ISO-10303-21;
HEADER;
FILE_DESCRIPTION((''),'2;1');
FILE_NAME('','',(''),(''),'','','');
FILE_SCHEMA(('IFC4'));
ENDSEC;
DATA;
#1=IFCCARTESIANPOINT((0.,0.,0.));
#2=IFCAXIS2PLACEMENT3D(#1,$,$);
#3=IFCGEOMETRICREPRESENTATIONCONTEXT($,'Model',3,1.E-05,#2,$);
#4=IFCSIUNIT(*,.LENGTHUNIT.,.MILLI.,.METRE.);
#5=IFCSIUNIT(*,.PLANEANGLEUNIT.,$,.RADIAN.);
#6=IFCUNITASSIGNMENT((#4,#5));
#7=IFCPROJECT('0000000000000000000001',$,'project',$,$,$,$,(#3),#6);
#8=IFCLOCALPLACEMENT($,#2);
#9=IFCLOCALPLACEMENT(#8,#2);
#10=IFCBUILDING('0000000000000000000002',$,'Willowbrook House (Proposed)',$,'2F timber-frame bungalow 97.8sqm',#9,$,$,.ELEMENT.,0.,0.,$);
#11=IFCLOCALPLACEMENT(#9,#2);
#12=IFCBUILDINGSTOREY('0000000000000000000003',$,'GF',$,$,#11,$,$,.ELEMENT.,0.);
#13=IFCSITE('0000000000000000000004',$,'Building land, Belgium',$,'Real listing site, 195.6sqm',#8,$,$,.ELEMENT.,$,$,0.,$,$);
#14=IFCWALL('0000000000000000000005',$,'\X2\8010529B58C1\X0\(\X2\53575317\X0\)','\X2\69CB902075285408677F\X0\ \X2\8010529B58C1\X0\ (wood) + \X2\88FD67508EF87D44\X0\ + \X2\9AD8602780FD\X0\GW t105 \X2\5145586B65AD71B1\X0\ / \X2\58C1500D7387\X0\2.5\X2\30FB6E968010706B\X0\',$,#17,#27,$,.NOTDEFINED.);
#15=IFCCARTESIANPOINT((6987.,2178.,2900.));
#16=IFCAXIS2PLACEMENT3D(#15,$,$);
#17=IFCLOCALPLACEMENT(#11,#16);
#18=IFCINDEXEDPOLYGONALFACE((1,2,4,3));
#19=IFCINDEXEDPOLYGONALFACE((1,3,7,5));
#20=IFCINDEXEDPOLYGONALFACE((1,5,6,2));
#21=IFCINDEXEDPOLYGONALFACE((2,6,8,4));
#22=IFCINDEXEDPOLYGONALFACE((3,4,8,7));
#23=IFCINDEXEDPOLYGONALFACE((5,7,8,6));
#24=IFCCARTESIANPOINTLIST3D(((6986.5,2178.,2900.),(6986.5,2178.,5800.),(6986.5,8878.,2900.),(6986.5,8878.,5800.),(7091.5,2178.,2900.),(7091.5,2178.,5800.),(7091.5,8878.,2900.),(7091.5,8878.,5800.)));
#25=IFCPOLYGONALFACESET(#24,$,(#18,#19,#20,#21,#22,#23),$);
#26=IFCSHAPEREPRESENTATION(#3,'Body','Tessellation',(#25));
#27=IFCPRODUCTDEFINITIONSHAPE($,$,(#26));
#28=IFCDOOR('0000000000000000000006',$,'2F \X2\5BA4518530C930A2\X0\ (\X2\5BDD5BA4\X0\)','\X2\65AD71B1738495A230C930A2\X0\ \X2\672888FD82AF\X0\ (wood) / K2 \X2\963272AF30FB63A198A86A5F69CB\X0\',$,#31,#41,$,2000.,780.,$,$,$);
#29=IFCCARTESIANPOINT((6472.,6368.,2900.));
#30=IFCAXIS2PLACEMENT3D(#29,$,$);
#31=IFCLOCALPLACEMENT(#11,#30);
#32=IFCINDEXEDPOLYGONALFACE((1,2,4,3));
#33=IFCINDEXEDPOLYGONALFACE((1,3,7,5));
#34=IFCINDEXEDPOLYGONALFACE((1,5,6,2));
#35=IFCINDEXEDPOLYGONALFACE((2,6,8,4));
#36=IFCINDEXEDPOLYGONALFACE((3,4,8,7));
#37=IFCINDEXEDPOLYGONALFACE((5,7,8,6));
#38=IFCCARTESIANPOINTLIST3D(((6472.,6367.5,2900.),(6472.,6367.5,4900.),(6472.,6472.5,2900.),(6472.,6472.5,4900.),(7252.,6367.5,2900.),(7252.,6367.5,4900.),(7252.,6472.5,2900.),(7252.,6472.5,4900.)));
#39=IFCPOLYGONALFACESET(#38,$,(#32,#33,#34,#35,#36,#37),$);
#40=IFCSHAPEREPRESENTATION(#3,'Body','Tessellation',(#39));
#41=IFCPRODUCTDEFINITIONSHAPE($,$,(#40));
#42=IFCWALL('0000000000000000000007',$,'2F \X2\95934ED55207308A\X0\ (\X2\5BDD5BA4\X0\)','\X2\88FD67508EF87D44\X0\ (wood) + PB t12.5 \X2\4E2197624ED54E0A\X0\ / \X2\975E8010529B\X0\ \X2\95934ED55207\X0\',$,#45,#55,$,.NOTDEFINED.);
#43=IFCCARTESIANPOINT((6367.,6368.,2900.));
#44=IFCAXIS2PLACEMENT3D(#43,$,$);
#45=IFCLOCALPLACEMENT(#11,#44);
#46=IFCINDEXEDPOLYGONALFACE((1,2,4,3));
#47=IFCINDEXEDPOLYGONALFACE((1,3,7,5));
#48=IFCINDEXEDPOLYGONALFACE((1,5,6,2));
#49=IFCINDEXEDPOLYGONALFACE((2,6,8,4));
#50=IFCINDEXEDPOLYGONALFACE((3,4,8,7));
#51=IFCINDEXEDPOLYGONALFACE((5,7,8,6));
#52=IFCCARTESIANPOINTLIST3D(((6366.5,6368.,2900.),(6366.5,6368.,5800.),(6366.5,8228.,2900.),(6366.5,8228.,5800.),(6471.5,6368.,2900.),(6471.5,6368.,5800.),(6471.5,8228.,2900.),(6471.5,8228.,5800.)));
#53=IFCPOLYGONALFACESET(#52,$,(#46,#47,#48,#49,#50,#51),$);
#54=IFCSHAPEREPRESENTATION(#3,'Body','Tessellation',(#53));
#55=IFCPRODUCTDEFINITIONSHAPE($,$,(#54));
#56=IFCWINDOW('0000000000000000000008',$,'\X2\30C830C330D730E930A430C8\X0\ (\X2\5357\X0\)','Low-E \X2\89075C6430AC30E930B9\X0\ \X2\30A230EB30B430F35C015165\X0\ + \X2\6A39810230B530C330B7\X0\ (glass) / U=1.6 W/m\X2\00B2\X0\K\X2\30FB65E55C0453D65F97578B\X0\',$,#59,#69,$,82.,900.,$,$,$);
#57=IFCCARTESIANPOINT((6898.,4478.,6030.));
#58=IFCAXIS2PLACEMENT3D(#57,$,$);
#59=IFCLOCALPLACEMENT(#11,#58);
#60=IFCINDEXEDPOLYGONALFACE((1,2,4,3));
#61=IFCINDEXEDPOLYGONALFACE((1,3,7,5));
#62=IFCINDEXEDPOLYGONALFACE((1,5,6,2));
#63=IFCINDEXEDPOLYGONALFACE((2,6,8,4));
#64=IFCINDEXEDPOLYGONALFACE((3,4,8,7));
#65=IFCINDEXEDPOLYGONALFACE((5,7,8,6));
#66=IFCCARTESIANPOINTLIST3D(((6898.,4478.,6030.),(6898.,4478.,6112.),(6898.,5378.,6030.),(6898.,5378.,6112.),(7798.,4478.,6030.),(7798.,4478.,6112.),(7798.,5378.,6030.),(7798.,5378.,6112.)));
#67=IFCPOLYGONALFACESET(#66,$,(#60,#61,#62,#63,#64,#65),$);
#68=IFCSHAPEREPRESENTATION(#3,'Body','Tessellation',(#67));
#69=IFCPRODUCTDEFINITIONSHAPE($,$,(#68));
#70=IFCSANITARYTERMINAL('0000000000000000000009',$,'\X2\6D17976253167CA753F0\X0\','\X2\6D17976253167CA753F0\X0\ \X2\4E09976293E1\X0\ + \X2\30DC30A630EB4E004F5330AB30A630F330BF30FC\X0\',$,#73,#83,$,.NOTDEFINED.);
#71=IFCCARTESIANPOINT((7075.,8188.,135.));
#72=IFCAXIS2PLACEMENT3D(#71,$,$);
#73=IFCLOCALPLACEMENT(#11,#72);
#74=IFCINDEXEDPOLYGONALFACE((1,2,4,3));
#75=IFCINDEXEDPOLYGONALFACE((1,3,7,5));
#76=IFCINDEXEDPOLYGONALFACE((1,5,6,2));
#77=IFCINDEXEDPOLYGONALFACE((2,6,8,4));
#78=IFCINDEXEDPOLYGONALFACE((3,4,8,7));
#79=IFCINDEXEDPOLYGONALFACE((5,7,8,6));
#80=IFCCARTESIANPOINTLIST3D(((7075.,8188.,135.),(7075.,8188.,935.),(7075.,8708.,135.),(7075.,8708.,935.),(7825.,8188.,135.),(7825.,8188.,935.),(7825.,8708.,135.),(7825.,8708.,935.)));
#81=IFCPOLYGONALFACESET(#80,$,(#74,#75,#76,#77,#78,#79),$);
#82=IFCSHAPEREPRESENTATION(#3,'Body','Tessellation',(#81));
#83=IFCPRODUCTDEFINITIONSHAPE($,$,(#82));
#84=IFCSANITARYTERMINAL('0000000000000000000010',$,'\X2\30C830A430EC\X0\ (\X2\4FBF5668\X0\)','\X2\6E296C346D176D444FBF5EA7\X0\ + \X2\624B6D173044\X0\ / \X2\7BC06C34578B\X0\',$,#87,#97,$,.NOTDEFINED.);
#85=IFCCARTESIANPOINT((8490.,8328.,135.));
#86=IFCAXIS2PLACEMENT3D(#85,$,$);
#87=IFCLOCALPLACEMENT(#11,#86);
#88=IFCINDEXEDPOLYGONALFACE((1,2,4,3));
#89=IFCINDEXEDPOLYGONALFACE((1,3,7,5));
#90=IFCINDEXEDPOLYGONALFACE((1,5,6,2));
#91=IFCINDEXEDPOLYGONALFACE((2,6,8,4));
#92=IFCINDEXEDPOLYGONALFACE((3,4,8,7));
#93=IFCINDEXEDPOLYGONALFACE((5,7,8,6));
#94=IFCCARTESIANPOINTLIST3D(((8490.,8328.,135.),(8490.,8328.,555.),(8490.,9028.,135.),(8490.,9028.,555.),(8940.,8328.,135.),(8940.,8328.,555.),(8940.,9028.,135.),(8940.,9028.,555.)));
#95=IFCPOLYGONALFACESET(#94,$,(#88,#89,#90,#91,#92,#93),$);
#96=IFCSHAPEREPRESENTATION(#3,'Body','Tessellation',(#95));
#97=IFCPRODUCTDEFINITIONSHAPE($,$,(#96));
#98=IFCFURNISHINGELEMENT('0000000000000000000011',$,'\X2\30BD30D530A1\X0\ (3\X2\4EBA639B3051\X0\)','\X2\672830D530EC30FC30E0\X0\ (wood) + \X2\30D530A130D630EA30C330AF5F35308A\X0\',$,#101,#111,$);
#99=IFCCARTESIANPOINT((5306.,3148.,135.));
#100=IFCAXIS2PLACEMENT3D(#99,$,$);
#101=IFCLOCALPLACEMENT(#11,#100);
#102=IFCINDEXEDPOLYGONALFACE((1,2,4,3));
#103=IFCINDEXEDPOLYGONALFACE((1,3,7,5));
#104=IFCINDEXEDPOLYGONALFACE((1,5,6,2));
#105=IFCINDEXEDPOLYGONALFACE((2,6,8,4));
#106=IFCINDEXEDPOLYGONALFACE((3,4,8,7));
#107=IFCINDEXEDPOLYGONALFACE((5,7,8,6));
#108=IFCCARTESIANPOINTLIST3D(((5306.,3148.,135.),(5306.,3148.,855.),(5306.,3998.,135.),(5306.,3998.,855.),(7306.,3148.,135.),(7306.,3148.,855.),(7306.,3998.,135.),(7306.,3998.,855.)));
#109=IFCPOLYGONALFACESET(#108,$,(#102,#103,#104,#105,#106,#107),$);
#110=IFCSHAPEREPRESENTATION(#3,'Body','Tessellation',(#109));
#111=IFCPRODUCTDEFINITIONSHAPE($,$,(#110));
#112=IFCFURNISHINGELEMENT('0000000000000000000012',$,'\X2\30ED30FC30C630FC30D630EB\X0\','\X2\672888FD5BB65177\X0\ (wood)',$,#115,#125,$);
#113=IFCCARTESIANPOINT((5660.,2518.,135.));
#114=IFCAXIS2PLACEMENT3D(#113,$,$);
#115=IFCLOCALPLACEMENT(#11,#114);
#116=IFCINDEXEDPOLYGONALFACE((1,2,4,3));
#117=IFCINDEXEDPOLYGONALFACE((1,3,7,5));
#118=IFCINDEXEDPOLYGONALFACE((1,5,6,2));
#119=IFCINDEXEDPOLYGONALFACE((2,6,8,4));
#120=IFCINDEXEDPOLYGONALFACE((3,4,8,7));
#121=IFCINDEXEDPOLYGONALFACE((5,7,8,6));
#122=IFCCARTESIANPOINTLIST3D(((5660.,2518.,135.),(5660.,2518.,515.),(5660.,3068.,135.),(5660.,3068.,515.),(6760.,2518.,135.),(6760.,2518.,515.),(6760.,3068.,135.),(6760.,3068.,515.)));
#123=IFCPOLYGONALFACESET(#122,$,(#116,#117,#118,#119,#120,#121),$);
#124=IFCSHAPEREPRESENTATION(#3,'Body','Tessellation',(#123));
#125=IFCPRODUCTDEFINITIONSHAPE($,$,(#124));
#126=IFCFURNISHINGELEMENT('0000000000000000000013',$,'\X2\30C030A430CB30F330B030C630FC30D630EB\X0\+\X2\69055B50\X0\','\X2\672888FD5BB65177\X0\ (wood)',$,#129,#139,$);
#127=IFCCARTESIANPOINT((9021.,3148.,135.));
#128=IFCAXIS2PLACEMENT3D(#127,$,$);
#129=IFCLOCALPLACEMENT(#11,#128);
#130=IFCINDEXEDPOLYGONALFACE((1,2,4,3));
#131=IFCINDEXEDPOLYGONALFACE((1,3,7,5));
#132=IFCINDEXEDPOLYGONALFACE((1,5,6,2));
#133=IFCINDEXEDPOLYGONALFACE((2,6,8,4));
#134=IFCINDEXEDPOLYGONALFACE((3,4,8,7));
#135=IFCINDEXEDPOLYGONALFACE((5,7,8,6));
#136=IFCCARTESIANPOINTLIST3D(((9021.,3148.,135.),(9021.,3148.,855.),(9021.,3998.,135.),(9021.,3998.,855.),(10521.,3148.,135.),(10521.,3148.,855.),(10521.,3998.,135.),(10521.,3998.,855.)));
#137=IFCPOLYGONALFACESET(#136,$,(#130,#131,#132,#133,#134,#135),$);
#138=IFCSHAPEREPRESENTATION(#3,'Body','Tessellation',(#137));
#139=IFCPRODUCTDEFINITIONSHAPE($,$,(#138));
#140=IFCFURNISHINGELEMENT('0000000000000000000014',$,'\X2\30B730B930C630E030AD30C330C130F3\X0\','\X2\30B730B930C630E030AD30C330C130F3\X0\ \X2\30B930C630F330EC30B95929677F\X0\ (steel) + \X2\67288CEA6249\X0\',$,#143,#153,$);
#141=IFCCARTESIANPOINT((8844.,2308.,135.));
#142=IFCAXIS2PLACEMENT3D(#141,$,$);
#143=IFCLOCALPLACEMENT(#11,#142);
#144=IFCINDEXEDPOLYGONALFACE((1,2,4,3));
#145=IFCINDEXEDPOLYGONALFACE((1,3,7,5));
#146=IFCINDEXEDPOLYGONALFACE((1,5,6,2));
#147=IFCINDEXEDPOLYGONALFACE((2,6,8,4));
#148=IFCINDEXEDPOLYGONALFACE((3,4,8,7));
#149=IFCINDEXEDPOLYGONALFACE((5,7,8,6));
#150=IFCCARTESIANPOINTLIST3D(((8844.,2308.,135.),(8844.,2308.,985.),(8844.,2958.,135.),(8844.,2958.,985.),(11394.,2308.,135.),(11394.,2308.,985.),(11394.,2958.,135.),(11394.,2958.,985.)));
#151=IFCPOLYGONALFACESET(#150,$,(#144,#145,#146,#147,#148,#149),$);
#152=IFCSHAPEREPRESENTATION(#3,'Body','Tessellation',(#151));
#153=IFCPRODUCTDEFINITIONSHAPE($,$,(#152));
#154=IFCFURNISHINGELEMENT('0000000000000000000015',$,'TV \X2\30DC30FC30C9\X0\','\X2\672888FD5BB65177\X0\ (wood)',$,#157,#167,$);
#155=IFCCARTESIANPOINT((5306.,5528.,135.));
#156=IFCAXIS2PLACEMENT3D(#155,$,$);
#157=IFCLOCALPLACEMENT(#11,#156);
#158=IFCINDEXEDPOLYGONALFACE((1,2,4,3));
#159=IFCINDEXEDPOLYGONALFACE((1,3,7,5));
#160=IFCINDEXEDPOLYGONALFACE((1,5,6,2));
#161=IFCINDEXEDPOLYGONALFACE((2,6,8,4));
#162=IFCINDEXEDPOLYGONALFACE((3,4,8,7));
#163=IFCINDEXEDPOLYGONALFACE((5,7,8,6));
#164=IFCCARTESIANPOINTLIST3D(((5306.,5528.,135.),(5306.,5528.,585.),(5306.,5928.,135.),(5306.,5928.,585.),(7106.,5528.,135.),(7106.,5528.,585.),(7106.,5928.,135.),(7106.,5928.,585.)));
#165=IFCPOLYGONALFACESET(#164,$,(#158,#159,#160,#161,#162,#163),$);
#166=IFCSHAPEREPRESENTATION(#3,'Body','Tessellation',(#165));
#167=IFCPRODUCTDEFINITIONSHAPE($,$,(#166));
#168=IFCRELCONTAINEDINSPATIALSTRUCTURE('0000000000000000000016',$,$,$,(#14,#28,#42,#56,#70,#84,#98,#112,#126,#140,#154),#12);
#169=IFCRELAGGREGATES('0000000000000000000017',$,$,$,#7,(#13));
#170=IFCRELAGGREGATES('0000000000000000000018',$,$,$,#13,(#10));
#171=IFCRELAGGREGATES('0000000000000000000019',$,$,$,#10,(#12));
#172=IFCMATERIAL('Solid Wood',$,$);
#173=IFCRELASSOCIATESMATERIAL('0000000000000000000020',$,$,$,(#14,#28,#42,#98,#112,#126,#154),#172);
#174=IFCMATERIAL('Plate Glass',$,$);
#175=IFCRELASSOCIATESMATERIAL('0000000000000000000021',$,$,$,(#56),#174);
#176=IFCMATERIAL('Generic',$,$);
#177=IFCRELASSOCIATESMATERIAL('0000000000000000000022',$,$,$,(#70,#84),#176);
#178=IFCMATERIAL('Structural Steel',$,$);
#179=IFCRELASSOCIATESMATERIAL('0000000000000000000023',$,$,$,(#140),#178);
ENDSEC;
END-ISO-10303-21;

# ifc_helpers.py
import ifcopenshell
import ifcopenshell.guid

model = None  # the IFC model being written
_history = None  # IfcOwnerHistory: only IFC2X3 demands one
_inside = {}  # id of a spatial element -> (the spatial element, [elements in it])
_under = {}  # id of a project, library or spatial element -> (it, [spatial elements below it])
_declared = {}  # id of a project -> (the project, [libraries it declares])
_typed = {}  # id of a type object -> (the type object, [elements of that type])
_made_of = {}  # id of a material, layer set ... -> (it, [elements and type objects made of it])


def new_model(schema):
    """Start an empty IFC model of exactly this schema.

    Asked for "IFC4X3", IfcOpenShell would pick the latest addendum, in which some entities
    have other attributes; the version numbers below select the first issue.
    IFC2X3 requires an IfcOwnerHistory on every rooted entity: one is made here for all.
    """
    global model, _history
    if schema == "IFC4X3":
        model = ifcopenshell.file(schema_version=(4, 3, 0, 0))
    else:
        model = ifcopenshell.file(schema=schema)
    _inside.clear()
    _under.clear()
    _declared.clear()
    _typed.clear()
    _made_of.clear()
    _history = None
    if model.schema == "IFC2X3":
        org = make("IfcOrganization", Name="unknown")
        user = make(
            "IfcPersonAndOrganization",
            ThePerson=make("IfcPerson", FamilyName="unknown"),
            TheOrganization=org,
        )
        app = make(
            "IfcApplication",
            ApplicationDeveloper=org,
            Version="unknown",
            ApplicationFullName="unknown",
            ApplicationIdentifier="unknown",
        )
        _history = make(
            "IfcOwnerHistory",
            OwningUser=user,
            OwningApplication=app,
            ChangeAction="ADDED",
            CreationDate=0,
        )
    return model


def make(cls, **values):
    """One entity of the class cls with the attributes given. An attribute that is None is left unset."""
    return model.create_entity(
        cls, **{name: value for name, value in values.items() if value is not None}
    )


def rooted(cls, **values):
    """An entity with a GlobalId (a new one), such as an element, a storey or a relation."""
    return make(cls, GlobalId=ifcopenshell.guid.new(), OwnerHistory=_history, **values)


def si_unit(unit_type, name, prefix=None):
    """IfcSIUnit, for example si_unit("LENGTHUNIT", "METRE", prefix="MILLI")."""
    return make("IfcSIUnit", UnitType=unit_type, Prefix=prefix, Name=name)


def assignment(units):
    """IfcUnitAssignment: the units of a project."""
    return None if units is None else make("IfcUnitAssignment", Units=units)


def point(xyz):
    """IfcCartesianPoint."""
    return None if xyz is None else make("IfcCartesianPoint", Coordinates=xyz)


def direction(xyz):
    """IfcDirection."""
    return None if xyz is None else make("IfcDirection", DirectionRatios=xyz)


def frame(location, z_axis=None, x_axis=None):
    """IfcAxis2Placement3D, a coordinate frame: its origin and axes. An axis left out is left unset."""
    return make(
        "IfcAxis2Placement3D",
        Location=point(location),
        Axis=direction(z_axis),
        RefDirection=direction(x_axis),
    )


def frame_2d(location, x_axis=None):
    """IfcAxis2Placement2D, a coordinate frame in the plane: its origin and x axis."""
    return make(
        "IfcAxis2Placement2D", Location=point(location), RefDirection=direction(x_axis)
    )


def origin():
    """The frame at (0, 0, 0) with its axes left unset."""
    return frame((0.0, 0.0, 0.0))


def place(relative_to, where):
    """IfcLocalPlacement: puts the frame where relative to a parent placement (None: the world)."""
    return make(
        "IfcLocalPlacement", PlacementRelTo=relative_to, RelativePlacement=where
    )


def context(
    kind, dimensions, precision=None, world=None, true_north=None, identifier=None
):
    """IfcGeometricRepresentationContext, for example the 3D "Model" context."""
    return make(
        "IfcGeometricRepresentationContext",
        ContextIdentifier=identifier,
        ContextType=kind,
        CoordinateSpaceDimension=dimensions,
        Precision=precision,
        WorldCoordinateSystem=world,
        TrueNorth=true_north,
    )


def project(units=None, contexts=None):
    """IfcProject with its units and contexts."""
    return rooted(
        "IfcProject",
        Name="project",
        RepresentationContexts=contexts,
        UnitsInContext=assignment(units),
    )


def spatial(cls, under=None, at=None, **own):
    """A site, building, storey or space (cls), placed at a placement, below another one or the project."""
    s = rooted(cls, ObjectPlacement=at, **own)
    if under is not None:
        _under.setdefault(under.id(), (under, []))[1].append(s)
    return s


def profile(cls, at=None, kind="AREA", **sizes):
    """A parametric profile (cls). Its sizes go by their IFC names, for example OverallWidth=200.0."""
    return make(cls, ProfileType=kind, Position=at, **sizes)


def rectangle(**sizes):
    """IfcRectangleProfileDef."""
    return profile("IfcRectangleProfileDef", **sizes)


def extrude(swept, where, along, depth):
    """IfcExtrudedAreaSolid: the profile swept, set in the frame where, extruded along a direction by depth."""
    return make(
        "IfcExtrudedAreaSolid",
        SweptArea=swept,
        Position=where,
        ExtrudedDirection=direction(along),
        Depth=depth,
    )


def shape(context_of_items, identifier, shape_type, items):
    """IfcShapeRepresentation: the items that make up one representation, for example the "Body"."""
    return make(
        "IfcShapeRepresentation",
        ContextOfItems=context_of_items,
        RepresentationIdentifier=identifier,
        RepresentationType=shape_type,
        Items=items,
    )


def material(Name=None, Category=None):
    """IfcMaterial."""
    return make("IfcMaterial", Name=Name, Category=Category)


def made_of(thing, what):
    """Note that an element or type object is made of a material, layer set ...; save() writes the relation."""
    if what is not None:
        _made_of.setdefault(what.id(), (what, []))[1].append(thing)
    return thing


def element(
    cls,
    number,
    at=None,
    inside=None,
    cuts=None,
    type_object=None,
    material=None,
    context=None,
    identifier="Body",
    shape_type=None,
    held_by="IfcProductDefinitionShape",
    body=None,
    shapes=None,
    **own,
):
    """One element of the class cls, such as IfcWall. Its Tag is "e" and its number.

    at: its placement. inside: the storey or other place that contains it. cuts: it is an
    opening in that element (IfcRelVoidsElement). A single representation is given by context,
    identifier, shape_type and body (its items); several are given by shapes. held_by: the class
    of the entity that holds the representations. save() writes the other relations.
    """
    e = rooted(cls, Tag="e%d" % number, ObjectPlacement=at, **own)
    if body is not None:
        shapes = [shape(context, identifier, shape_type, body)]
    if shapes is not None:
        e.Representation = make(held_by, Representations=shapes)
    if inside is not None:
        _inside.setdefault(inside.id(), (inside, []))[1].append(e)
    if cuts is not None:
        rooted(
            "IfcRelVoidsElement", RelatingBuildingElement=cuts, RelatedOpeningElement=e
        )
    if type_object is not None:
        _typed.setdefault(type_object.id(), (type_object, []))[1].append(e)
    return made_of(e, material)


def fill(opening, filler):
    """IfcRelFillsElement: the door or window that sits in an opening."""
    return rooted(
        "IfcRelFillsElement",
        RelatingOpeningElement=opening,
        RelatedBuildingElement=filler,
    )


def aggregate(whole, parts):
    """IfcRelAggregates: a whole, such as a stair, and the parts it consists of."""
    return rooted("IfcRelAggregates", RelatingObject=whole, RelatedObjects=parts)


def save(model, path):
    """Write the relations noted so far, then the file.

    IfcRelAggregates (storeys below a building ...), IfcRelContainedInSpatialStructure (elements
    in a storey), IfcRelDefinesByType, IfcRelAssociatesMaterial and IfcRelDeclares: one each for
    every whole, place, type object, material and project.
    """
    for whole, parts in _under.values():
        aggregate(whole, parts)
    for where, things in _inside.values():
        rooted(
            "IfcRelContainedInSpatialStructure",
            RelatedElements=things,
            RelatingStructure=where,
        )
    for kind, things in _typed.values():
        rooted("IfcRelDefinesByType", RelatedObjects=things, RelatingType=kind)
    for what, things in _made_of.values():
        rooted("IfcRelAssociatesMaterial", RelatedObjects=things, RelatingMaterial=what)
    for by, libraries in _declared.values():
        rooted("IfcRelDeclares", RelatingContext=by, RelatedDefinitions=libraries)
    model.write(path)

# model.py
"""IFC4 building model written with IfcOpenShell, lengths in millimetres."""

from ifc_helpers import new_model, si_unit, frame, frame_2d, origin, place, context, project, spatial, rectangle, extrude, material, element, fill, save


model = new_model("IFC4")

# Units and contexts
model_context = context("Model", 3, precision=1e-05, world=origin())
ifc_project = project(units=[si_unit("LENGTHUNIT", "METRE", prefix="MILLI"), si_unit("PLANEANGLEUNIT", "RADIAN")], contexts=[model_context])

# Site, building, storey
site_placement = place(None, origin())
site = spatial("IfcSite", under=ifc_project, at=site_placement, Name="Building land, Belgium", ObjectType="Real listing site, 195.6sqm", CompositionType="ELEMENT", RefElevation=0.0)
building_placement = place(site_placement, origin())
building = spatial("IfcBuilding", under=site, at=building_placement, Name="Willowbrook House (Proposed)", ObjectType="2F timber-frame bungalow 97.8sqm", CompositionType="ELEMENT", ElevationOfRefHeight=0.0, ElevationOfTerrain=0.0)
storey_placement = place(building_placement, origin())
storey = spatial("IfcBuildingStorey", under=building, at=storey_placement, Name="GF", CompositionType="ELEMENT", Elevation=0.0)

# Shared definitions
ifc_material_1 = material(Name="Solid Wood")

# Wall, opening, door
wall_1_placement = place(storey_placement, frame((6987.0, 2178.0, 2900.0)))
wall_1 = element("IfcWall", 1, at=wall_1_placement, inside=storey, material=ifc_material_1, Name="耐力壁(南北)", Description="構造用合板 耐力壁 (wood) + 製材軸組 + 高性能GW t105 充填断熱 / 壁倍率2.5・準耐火", PredefinedType="NOTDEFINED", context=model_context, shape_type="SweptSolid", body=[
    extrude(rectangle(XDim=105.0, YDim=6700.0, at=frame_2d((52.0, 3350.0))), frame((6987.0, 2178.0, 2900.0)), (0.0, 0.0, 1.0), 2900.0),
])
opening_1_placement = place(storey_placement, frame((6472.0, 6368.0, 2900.0)))
opening_1 = element("IfcOpeningElement", 2, at=opening_1_placement, cuts=wall_1, PredefinedType="NOTDEFINED", context=model_context, shape_type="SweptSolid", body=[
    extrude(rectangle(XDim=780.0, YDim=105.0, at=frame_2d((390.0, 52.0))), frame((6472.0, 6368.0, 2900.0)), (0.0, 0.0, 1.0), 2000.0),
])
door_1_placement = place(storey_placement, frame((6472.0, 6368.0, 2900.0)))
door_1 = element("IfcDoor", 3, at=door_1_placement, inside=storey, material=ifc_material_1, Name="2F 室内ドア (寝室)", Description="断熱玄関ドア 木製芯 (wood) / K2 防犯・採風機構", OverallHeight=2000.0, OverallWidth=780.0, context=model_context, shape_type="SweptSolid", body=[
    extrude(rectangle(XDim=780.0, YDim=105.0, at=frame_2d((390.0, 52.0))), frame((6472.0, 6368.0, 2900.0)), (0.0, 0.0, 1.0), 2000.0),
])
fill(opening_1, door_1)

# Wall
wall_2_placement = place(storey_placement, frame((6367.0, 6368.0, 2900.0)))
element("IfcWall", 4, at=wall_2_placement, inside=storey, material=ifc_material_1, Name="2F 間仕切り (寝室)", Description="製材軸組 (wood) + PB t12.5 両面仕上 / 非耐力 間仕切", PredefinedType="NOTDEFINED", context=model_context, shape_type="SweptSolid", body=[
    extrude(rectangle(XDim=105.0, YDim=1860.0, at=frame_2d((52.0, 930.0))), frame((6367.0, 6368.0, 2900.0)), (0.0, 0.0, 1.0), 2900.0),
])

# Window
ifc_material_2 = material(Name="Plate Glass")
window_placement = place(storey_placement, frame((6898.0, 4478.0, 6030.0)))
element("IfcWindow", 5, at=window_placement, inside=storey, material=ifc_material_2, Name="トップライト (南)", Description="Low-E 複層ガラス アルゴン封入 + 樹脂サッシ (glass) / U=1.6 W/m²K・日射取得型", OverallHeight=82.0, OverallWidth=900.0, context=model_context, shape_type="SweptSolid", body=[
    extrude(rectangle(XDim=900.0, YDim=900.0, at=frame_2d((450.0, 450.0))), frame((6898.0, 4478.0, 6030.0)), (0.0, 0.0, 1.0), 82.0),
])

# Sanitary terminals
ifc_material_3 = material(Name="Generic")
sanitary_terminal_1_placement = place(storey_placement, frame((7075.0, 8188.0, 135.0)))
element("IfcSanitaryTerminal", 6, at=sanitary_terminal_1_placement, inside=storey, material=ifc_material_3, Name="洗面化粧台", Description="洗面化粧台 三面鏡 + ボウル一体カウンター", PredefinedType="NOTDEFINED", context=model_context, shape_type="SweptSolid", body=[
    extrude(rectangle(XDim=750.0, YDim=520.0, at=frame_2d((375.0, 260.0))), frame((7075.0, 8188.0, 135.0)), (0.0, 0.0, 1.0), 800.0),
])
sanitary_terminal_2_placement = place(storey_placement, frame((8490.0, 8328.0, 135.0)))
element("IfcSanitaryTerminal", 7, at=sanitary_terminal_2_placement, inside=storey, material=ifc_material_3, Name="トイレ (便器)", Description="温水洗浄便座 + 手洗い / 節水型", PredefinedType="NOTDEFINED", context=model_context, shape_type="SweptSolid", body=[
    extrude(rectangle(XDim=450.0, YDim=700.0, at=frame_2d((225.0, 350.0))), frame((8490.0, 8328.0, 135.0)), (0.0, 0.0, 1.0), 420.0),
])

# Furnishing elements
furnishing_1_placement = place(storey_placement, frame((5306.0, 3148.0, 135.0)))
element("IfcFurnishingElement", 8, at=furnishing_1_placement, inside=storey, material=ifc_material_1, Name="ソファ (3人掛け)", Description="木フレーム (wood) + ファブリック張り", context=model_context, shape_type="SweptSolid", body=[
    extrude(rectangle(XDim=2000.0, YDim=850.0, at=frame_2d((1000.0, 425.0))), frame((5306.0, 3148.0, 135.0)), (0.0, 0.0, 1.0), 720.0),
])
furnishing_2_placement = place(storey_placement, frame((5660.0, 2518.0, 135.0)))
element("IfcFurnishingElement", 9, at=furnishing_2_placement, inside=storey, material=ifc_material_1, Name="ローテーブル", Description="木製家具 (wood)", context=model_context, shape_type="SweptSolid", body=[
    extrude(rectangle(XDim=1100.0, YDim=550.0, at=frame_2d((550.0, 275.0))), frame((5660.0, 2518.0, 135.0)), (0.0, 0.0, 1.0), 380.0),
])
furnishing_3_placement = place(storey_placement, frame((9021.0, 3148.0, 135.0)))
element("IfcFurnishingElement", 10, at=furnishing_3_placement, inside=storey, material=ifc_material_1, Name="ダイニングテーブル+椅子", Description="木製家具 (wood)", context=model_context, shape_type="SweptSolid", body=[
    extrude(rectangle(XDim=1500.0, YDim=850.0, at=frame_2d((750.0, 425.0))), frame((9021.0, 3148.0, 135.0)), (0.0, 0.0, 1.0), 720.0),
])
ifc_material_4 = material(Name="Structural Steel")
furnishing_4_placement = place(storey_placement, frame((8844.0, 2308.0, 135.0)))
element("IfcFurnishingElement", 11, at=furnishing_4_placement, inside=storey, material=ifc_material_4, Name="システムキッチン", Description="システムキッチン ステンレス天板 (steel) + 木質扉", context=model_context, shape_type="SweptSolid", body=[
    extrude(rectangle(XDim=2550.0, YDim=650.0, at=frame_2d((1275.0, 325.0))), frame((8844.0, 2308.0, 135.0)), (0.0, 0.0, 1.0), 850.0),
])
furnishing_5_placement = place(storey_placement, frame((5306.0, 5528.0, 135.0)))
element("IfcFurnishingElement", 12, at=furnishing_5_placement, inside=storey, material=ifc_material_1, Name="TV ボード", Description="木製家具 (wood)", context=model_context, shape_type="SweptSolid", body=[
    extrude(rectangle(XDim=1800.0, YDim=400.0, at=frame_2d((900.0, 200.0))), frame((5306.0, 5528.0, 135.0)), (0.0, 0.0, 1.0), 450.0),
])

save(model, "model.ifc")
